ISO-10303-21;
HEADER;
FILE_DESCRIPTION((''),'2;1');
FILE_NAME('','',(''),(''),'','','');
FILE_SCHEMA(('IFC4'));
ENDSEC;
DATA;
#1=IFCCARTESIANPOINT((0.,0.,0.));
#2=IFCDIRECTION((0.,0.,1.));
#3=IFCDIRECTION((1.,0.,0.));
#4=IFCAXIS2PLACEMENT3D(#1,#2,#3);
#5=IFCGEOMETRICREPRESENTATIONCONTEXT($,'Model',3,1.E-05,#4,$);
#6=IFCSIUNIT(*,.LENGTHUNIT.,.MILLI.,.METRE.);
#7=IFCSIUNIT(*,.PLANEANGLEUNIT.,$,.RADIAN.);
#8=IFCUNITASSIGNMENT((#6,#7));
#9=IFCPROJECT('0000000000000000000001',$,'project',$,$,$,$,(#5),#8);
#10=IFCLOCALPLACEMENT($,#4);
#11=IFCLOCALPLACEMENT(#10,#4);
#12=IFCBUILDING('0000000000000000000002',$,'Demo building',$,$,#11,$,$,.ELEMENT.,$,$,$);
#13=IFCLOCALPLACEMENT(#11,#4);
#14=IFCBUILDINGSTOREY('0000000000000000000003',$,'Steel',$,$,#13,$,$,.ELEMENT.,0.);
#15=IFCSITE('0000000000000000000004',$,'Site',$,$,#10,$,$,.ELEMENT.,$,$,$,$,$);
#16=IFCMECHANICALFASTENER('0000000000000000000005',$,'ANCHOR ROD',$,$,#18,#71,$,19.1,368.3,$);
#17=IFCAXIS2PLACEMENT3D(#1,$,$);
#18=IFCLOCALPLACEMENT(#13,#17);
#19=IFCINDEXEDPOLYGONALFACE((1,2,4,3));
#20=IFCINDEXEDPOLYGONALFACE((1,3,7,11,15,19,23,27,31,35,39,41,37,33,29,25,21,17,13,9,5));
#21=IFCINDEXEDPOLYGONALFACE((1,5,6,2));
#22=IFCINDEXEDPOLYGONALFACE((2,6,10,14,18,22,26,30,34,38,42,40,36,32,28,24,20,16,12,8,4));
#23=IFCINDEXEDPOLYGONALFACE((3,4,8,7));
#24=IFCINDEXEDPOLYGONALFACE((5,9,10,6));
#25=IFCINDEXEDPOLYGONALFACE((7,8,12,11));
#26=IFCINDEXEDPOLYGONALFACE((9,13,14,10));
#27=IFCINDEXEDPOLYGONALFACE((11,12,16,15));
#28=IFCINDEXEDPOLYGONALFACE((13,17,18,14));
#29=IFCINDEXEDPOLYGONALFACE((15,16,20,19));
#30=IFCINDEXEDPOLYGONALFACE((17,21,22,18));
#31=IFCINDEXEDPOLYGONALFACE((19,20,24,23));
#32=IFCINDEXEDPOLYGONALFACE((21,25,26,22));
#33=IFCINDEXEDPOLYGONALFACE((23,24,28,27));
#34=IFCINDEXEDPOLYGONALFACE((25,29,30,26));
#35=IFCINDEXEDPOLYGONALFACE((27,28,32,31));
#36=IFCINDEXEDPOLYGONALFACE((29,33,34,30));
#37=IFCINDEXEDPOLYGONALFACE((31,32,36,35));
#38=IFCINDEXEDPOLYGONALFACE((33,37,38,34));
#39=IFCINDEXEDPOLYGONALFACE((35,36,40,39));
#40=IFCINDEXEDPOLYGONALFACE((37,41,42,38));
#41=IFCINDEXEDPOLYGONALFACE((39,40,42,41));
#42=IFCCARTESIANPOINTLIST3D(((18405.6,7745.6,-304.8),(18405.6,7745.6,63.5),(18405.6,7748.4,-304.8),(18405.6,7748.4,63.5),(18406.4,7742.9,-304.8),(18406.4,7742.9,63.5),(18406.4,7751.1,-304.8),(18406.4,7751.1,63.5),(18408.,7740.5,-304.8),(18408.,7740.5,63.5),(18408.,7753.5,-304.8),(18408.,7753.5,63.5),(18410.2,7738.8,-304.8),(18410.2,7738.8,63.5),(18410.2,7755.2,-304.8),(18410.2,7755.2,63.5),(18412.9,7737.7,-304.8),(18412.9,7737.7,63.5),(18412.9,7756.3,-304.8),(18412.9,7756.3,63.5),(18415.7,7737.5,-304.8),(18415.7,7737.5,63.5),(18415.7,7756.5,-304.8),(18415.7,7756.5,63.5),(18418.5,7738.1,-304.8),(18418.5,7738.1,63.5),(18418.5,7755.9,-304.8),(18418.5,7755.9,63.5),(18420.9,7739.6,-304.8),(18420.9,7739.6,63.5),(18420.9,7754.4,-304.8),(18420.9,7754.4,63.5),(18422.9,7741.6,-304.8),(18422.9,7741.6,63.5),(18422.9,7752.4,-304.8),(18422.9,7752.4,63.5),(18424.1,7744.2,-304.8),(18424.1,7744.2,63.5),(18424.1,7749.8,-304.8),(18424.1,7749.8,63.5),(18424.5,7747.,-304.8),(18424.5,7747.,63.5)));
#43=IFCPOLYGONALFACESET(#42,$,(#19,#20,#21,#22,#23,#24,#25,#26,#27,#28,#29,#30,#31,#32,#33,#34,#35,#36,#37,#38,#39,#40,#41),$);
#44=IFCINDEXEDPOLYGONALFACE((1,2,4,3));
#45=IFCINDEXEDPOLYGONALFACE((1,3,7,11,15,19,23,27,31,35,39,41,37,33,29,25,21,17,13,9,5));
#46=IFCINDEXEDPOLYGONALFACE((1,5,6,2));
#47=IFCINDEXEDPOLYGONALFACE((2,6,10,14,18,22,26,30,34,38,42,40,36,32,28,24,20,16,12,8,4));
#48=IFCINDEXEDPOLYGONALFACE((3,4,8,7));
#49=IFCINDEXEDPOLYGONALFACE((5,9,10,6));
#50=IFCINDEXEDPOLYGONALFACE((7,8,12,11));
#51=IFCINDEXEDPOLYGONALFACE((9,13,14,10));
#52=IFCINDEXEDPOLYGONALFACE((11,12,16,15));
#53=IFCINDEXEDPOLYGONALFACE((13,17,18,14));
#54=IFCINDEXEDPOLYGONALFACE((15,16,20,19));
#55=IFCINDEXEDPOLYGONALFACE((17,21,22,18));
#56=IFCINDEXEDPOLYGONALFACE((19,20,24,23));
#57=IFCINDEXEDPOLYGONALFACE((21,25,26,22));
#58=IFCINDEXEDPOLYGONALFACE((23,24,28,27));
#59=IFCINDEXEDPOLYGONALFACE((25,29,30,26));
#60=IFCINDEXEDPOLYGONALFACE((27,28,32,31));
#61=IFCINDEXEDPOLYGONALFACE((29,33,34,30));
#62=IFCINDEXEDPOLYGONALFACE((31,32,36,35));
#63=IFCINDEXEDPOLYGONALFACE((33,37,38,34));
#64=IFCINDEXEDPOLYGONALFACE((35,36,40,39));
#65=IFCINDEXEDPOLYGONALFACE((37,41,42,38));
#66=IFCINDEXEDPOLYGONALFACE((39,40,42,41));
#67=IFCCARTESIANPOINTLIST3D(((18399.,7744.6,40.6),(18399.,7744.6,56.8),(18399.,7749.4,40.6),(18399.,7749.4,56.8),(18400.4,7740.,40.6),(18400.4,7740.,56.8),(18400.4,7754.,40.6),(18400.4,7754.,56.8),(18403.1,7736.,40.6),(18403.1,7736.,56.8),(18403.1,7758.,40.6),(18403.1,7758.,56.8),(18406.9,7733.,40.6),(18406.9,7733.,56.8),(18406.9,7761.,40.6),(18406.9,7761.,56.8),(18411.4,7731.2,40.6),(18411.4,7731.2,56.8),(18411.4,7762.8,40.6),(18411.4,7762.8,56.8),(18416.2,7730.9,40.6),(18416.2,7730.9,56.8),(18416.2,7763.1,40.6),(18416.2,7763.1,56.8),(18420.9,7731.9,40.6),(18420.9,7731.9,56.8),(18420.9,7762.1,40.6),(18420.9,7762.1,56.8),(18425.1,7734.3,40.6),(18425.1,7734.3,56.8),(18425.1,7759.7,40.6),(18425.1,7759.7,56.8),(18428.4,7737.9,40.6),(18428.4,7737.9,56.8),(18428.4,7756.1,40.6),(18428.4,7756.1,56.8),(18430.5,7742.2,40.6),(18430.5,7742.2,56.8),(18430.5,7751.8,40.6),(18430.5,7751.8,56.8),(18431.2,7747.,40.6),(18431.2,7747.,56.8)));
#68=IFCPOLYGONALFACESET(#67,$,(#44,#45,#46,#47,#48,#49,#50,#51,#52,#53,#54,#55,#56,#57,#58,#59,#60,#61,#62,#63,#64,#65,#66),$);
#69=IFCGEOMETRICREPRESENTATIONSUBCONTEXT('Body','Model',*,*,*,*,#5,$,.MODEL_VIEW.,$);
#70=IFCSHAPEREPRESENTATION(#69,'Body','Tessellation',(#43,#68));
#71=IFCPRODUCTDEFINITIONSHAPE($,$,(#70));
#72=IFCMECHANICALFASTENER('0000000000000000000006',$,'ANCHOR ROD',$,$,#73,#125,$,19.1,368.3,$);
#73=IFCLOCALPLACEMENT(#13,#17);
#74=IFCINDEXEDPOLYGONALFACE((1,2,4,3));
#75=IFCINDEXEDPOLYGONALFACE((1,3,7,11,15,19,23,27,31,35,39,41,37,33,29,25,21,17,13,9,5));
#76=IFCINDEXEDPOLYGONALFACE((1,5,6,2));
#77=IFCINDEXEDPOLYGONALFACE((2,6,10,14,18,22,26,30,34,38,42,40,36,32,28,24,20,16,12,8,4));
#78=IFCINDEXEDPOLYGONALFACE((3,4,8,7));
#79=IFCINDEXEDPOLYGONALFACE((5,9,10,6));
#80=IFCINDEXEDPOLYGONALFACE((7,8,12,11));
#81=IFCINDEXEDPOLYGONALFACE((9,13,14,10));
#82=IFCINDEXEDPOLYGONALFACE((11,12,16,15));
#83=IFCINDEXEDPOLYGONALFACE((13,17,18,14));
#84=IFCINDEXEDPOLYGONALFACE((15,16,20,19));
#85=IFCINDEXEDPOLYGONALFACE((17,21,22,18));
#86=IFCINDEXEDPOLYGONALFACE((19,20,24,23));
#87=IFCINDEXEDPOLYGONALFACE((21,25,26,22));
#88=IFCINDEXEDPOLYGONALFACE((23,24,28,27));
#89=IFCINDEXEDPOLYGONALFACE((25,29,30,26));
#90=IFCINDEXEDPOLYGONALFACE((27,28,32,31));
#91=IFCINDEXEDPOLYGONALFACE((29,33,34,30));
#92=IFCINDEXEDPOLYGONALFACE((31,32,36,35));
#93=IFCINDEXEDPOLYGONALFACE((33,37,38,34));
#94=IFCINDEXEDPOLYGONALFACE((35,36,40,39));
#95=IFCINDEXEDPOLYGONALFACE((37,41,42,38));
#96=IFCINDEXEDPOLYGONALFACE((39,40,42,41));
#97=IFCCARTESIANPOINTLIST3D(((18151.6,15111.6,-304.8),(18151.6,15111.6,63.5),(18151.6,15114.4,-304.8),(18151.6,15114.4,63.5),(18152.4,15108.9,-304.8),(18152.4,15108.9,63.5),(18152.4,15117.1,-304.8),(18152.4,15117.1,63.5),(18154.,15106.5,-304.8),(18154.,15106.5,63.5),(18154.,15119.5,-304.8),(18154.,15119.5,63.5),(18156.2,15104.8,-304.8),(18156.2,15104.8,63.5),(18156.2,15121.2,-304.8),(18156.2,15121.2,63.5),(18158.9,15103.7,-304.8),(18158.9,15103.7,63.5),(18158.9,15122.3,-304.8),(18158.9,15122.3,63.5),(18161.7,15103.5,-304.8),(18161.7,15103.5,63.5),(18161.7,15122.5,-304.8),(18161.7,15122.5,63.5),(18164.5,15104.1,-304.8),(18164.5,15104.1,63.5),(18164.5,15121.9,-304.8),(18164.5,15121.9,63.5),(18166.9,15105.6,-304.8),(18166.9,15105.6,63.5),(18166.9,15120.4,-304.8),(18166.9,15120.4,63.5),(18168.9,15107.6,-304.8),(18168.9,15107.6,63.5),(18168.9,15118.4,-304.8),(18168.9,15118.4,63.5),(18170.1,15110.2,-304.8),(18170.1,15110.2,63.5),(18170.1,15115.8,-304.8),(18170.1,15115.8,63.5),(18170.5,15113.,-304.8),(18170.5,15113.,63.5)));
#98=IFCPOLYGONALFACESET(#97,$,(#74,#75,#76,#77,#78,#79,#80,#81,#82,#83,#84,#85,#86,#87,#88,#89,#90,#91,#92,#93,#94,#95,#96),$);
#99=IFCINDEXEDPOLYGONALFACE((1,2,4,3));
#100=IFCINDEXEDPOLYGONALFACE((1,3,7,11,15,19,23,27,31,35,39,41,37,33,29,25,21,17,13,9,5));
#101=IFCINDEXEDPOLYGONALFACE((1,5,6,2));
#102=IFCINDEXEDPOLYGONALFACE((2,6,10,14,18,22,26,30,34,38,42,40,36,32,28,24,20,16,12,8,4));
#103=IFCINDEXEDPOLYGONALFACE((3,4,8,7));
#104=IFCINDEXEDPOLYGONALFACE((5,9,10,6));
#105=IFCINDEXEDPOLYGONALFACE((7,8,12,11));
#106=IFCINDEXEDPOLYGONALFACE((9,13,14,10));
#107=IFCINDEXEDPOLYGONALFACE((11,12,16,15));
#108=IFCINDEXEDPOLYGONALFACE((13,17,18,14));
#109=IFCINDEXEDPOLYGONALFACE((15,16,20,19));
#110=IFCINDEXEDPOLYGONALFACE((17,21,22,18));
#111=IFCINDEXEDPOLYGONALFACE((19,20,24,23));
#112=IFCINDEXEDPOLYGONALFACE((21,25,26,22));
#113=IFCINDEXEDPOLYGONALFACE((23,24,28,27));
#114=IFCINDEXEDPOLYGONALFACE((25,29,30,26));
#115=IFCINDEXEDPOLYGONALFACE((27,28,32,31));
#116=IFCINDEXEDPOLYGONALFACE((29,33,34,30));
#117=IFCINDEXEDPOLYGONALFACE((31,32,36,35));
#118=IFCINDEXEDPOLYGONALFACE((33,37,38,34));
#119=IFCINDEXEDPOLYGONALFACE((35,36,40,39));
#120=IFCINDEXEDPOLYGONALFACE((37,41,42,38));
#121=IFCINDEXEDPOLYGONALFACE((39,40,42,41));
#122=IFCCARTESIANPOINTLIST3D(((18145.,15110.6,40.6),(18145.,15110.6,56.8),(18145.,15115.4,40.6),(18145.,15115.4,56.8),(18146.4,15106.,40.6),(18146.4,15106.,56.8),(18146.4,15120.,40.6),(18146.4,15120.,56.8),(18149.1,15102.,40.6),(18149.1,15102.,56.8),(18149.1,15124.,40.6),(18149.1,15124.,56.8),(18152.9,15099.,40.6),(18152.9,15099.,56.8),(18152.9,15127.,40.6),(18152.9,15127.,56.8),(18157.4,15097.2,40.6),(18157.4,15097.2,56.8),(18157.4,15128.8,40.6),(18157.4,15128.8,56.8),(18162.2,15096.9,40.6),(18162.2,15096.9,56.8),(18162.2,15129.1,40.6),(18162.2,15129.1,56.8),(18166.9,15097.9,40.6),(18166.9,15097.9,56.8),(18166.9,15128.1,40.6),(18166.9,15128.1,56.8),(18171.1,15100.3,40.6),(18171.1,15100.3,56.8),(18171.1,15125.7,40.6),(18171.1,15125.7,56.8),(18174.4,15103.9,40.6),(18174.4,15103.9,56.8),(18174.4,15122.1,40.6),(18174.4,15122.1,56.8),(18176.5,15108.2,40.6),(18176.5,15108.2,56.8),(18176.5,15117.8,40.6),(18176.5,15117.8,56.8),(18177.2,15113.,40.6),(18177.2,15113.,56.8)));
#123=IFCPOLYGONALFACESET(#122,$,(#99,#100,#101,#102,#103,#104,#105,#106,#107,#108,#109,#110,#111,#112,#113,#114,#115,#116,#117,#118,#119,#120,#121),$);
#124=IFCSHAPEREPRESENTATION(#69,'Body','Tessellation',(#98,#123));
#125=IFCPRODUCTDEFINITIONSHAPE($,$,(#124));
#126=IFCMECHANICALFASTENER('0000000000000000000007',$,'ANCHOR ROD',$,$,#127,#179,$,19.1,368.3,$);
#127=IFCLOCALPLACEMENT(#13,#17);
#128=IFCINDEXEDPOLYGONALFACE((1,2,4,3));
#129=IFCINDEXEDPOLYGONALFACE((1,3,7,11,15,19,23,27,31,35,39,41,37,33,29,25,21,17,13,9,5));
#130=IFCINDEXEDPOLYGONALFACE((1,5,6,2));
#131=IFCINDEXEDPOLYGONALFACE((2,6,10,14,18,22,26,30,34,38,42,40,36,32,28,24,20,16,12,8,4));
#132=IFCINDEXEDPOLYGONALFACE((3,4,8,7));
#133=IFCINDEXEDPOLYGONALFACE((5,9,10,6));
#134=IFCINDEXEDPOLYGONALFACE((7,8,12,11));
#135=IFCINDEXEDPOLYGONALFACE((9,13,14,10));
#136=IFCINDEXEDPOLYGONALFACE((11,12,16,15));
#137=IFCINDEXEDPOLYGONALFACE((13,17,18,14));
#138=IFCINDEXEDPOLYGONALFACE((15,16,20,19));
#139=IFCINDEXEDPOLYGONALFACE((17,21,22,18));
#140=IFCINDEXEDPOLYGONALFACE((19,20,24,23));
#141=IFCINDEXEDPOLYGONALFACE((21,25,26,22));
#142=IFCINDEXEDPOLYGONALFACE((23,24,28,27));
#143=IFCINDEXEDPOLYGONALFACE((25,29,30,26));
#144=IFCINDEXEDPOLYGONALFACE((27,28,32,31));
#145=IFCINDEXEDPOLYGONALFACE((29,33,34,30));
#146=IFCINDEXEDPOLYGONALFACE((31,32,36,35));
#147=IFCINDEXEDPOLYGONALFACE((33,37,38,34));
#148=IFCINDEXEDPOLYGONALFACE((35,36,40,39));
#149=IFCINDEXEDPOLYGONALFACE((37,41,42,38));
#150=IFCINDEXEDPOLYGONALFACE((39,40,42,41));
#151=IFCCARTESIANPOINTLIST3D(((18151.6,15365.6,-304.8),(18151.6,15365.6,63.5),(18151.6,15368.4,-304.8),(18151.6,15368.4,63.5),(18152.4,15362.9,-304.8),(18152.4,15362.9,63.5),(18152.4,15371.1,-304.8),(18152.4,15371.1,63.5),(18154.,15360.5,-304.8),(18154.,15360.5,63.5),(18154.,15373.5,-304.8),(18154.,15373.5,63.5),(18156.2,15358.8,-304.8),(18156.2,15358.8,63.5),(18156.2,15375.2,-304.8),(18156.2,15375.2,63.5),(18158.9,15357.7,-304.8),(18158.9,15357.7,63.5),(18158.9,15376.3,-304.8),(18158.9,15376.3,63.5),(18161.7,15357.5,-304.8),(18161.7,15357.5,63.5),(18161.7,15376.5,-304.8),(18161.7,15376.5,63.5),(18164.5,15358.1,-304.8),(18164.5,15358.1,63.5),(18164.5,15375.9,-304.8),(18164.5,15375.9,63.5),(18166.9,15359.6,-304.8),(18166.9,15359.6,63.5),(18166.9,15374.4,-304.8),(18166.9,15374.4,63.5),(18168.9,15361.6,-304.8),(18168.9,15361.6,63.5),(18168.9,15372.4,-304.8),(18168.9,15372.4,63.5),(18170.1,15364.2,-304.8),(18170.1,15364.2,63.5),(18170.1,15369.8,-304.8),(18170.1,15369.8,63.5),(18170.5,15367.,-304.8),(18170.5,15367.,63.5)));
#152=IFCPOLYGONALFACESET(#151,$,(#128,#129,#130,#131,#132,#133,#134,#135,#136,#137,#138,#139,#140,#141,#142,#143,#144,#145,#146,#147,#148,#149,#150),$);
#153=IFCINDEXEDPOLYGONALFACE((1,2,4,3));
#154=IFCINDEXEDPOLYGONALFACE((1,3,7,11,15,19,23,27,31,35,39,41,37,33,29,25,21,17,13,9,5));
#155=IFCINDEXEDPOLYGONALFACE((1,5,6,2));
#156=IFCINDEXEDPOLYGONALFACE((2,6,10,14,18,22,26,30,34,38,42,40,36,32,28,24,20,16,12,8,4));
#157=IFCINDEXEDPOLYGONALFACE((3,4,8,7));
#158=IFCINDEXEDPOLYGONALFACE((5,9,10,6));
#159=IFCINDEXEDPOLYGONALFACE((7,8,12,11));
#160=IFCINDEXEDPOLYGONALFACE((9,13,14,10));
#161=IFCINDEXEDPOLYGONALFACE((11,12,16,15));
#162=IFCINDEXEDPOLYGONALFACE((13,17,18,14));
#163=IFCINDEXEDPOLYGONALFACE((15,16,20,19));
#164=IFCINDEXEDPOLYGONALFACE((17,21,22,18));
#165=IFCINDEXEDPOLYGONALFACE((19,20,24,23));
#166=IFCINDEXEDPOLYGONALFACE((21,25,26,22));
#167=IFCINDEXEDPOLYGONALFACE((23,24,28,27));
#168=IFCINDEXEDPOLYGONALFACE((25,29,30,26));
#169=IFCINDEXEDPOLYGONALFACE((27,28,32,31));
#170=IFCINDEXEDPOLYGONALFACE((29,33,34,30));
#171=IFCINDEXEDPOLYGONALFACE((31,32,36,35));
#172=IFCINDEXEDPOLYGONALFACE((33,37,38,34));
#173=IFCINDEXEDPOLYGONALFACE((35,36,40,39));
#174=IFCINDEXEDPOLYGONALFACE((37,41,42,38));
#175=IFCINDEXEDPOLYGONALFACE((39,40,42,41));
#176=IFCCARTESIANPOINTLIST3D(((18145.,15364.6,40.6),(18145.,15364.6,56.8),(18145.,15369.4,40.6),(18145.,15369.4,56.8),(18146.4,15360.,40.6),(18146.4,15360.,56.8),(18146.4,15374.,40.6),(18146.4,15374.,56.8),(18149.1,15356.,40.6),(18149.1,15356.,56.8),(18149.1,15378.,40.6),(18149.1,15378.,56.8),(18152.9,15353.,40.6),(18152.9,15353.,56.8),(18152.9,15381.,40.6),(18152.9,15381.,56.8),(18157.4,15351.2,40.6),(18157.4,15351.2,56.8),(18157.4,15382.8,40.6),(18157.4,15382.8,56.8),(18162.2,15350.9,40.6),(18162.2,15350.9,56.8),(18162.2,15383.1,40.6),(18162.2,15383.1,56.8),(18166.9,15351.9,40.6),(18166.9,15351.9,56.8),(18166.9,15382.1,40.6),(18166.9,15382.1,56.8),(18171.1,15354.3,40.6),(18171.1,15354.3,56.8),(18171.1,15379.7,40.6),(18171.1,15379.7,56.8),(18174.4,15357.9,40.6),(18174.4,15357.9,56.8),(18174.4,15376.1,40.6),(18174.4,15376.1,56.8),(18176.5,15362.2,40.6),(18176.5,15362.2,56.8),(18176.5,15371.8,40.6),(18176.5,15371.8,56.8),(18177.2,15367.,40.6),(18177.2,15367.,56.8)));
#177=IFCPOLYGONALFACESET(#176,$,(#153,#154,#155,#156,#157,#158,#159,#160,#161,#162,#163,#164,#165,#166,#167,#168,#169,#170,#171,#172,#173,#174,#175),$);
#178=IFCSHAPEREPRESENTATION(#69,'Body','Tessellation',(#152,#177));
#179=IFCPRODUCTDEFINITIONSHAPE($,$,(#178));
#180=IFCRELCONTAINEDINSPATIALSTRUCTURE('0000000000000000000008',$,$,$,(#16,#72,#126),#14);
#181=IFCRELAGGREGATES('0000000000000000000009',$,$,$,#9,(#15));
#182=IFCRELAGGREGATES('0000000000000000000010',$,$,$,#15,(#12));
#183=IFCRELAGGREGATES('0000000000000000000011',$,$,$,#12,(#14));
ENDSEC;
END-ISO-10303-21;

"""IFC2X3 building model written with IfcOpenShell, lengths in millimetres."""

from ifc_helpers import new_model, si_unit, frame, origin, origin_with_axes, origin_2d, place, context, subcontext, project, spatial, circle, extrude, element, save


model = new_model("IFC2X3")

# Units and contexts
model_context = context("Model", 3, precision=1e-05, world=origin_with_axes())
body_context = subcontext(model_context, "Body", "Model", "MODEL_VIEW")
ifc_project = project(units=[si_unit("LENGTHUNIT", "METRE", prefix="MILLI"), si_unit("PLANEANGLEUNIT", "RADIAN")], contexts=[model_context])

# Site, building, storey
site_placement = place(None, origin_with_axes())
site = spatial("IfcSite", under=ifc_project, at=site_placement, Name="Site", CompositionType="ELEMENT")
building_placement = place(site_placement, origin_with_axes())
building = spatial("IfcBuilding", under=site, at=building_placement, Name="Demo building", CompositionType="ELEMENT")
placement = place(building_placement, origin_with_axes())
storey = spatial("IfcBuildingStorey", under=building, at=placement, Name="Steel", CompositionType="ELEMENT", Elevation=0.0)

# Mechanical fasteners
for number, where, z_axis, x_axis, name in (
    (1, (18415.0, 7747.0, -304.8), (0.0, 0.0, 1.0), (1.0, 0.0, 0.0), "ANCHOR ROD"),
    (2, (18161.0, 15113.0, -304.8), (0.0, 0.0, 1.0), (1.0, 0.0, 0.0), "ANCHOR ROD"),
    (3, (18161.0, 15367.0, -304.8), (0.0, 0.0, 1.0), (1.0, 0.0, 0.0), "ANCHOR ROD"),
):
    element("IfcMechanicalFastener", number, at=place(placement, frame(where, z_axis=z_axis, x_axis=x_axis)), inside=storey, Name=name, NominalDiameter=19.1, NominalLength=368.3, context=body_context, shape_type="SweptSolid", body=[
        extrude(circle(Radius=9.5, at=origin_2d()), origin(), (0.0, 0.0, 1.0), 368.3),
        extrude(circle(Radius=16.2, at=origin_2d()), frame((0.0, 0.0, 345.4)), (0.0, 0.0, 1.0), 16.2),
    ])

save(model, "model.ifc")
